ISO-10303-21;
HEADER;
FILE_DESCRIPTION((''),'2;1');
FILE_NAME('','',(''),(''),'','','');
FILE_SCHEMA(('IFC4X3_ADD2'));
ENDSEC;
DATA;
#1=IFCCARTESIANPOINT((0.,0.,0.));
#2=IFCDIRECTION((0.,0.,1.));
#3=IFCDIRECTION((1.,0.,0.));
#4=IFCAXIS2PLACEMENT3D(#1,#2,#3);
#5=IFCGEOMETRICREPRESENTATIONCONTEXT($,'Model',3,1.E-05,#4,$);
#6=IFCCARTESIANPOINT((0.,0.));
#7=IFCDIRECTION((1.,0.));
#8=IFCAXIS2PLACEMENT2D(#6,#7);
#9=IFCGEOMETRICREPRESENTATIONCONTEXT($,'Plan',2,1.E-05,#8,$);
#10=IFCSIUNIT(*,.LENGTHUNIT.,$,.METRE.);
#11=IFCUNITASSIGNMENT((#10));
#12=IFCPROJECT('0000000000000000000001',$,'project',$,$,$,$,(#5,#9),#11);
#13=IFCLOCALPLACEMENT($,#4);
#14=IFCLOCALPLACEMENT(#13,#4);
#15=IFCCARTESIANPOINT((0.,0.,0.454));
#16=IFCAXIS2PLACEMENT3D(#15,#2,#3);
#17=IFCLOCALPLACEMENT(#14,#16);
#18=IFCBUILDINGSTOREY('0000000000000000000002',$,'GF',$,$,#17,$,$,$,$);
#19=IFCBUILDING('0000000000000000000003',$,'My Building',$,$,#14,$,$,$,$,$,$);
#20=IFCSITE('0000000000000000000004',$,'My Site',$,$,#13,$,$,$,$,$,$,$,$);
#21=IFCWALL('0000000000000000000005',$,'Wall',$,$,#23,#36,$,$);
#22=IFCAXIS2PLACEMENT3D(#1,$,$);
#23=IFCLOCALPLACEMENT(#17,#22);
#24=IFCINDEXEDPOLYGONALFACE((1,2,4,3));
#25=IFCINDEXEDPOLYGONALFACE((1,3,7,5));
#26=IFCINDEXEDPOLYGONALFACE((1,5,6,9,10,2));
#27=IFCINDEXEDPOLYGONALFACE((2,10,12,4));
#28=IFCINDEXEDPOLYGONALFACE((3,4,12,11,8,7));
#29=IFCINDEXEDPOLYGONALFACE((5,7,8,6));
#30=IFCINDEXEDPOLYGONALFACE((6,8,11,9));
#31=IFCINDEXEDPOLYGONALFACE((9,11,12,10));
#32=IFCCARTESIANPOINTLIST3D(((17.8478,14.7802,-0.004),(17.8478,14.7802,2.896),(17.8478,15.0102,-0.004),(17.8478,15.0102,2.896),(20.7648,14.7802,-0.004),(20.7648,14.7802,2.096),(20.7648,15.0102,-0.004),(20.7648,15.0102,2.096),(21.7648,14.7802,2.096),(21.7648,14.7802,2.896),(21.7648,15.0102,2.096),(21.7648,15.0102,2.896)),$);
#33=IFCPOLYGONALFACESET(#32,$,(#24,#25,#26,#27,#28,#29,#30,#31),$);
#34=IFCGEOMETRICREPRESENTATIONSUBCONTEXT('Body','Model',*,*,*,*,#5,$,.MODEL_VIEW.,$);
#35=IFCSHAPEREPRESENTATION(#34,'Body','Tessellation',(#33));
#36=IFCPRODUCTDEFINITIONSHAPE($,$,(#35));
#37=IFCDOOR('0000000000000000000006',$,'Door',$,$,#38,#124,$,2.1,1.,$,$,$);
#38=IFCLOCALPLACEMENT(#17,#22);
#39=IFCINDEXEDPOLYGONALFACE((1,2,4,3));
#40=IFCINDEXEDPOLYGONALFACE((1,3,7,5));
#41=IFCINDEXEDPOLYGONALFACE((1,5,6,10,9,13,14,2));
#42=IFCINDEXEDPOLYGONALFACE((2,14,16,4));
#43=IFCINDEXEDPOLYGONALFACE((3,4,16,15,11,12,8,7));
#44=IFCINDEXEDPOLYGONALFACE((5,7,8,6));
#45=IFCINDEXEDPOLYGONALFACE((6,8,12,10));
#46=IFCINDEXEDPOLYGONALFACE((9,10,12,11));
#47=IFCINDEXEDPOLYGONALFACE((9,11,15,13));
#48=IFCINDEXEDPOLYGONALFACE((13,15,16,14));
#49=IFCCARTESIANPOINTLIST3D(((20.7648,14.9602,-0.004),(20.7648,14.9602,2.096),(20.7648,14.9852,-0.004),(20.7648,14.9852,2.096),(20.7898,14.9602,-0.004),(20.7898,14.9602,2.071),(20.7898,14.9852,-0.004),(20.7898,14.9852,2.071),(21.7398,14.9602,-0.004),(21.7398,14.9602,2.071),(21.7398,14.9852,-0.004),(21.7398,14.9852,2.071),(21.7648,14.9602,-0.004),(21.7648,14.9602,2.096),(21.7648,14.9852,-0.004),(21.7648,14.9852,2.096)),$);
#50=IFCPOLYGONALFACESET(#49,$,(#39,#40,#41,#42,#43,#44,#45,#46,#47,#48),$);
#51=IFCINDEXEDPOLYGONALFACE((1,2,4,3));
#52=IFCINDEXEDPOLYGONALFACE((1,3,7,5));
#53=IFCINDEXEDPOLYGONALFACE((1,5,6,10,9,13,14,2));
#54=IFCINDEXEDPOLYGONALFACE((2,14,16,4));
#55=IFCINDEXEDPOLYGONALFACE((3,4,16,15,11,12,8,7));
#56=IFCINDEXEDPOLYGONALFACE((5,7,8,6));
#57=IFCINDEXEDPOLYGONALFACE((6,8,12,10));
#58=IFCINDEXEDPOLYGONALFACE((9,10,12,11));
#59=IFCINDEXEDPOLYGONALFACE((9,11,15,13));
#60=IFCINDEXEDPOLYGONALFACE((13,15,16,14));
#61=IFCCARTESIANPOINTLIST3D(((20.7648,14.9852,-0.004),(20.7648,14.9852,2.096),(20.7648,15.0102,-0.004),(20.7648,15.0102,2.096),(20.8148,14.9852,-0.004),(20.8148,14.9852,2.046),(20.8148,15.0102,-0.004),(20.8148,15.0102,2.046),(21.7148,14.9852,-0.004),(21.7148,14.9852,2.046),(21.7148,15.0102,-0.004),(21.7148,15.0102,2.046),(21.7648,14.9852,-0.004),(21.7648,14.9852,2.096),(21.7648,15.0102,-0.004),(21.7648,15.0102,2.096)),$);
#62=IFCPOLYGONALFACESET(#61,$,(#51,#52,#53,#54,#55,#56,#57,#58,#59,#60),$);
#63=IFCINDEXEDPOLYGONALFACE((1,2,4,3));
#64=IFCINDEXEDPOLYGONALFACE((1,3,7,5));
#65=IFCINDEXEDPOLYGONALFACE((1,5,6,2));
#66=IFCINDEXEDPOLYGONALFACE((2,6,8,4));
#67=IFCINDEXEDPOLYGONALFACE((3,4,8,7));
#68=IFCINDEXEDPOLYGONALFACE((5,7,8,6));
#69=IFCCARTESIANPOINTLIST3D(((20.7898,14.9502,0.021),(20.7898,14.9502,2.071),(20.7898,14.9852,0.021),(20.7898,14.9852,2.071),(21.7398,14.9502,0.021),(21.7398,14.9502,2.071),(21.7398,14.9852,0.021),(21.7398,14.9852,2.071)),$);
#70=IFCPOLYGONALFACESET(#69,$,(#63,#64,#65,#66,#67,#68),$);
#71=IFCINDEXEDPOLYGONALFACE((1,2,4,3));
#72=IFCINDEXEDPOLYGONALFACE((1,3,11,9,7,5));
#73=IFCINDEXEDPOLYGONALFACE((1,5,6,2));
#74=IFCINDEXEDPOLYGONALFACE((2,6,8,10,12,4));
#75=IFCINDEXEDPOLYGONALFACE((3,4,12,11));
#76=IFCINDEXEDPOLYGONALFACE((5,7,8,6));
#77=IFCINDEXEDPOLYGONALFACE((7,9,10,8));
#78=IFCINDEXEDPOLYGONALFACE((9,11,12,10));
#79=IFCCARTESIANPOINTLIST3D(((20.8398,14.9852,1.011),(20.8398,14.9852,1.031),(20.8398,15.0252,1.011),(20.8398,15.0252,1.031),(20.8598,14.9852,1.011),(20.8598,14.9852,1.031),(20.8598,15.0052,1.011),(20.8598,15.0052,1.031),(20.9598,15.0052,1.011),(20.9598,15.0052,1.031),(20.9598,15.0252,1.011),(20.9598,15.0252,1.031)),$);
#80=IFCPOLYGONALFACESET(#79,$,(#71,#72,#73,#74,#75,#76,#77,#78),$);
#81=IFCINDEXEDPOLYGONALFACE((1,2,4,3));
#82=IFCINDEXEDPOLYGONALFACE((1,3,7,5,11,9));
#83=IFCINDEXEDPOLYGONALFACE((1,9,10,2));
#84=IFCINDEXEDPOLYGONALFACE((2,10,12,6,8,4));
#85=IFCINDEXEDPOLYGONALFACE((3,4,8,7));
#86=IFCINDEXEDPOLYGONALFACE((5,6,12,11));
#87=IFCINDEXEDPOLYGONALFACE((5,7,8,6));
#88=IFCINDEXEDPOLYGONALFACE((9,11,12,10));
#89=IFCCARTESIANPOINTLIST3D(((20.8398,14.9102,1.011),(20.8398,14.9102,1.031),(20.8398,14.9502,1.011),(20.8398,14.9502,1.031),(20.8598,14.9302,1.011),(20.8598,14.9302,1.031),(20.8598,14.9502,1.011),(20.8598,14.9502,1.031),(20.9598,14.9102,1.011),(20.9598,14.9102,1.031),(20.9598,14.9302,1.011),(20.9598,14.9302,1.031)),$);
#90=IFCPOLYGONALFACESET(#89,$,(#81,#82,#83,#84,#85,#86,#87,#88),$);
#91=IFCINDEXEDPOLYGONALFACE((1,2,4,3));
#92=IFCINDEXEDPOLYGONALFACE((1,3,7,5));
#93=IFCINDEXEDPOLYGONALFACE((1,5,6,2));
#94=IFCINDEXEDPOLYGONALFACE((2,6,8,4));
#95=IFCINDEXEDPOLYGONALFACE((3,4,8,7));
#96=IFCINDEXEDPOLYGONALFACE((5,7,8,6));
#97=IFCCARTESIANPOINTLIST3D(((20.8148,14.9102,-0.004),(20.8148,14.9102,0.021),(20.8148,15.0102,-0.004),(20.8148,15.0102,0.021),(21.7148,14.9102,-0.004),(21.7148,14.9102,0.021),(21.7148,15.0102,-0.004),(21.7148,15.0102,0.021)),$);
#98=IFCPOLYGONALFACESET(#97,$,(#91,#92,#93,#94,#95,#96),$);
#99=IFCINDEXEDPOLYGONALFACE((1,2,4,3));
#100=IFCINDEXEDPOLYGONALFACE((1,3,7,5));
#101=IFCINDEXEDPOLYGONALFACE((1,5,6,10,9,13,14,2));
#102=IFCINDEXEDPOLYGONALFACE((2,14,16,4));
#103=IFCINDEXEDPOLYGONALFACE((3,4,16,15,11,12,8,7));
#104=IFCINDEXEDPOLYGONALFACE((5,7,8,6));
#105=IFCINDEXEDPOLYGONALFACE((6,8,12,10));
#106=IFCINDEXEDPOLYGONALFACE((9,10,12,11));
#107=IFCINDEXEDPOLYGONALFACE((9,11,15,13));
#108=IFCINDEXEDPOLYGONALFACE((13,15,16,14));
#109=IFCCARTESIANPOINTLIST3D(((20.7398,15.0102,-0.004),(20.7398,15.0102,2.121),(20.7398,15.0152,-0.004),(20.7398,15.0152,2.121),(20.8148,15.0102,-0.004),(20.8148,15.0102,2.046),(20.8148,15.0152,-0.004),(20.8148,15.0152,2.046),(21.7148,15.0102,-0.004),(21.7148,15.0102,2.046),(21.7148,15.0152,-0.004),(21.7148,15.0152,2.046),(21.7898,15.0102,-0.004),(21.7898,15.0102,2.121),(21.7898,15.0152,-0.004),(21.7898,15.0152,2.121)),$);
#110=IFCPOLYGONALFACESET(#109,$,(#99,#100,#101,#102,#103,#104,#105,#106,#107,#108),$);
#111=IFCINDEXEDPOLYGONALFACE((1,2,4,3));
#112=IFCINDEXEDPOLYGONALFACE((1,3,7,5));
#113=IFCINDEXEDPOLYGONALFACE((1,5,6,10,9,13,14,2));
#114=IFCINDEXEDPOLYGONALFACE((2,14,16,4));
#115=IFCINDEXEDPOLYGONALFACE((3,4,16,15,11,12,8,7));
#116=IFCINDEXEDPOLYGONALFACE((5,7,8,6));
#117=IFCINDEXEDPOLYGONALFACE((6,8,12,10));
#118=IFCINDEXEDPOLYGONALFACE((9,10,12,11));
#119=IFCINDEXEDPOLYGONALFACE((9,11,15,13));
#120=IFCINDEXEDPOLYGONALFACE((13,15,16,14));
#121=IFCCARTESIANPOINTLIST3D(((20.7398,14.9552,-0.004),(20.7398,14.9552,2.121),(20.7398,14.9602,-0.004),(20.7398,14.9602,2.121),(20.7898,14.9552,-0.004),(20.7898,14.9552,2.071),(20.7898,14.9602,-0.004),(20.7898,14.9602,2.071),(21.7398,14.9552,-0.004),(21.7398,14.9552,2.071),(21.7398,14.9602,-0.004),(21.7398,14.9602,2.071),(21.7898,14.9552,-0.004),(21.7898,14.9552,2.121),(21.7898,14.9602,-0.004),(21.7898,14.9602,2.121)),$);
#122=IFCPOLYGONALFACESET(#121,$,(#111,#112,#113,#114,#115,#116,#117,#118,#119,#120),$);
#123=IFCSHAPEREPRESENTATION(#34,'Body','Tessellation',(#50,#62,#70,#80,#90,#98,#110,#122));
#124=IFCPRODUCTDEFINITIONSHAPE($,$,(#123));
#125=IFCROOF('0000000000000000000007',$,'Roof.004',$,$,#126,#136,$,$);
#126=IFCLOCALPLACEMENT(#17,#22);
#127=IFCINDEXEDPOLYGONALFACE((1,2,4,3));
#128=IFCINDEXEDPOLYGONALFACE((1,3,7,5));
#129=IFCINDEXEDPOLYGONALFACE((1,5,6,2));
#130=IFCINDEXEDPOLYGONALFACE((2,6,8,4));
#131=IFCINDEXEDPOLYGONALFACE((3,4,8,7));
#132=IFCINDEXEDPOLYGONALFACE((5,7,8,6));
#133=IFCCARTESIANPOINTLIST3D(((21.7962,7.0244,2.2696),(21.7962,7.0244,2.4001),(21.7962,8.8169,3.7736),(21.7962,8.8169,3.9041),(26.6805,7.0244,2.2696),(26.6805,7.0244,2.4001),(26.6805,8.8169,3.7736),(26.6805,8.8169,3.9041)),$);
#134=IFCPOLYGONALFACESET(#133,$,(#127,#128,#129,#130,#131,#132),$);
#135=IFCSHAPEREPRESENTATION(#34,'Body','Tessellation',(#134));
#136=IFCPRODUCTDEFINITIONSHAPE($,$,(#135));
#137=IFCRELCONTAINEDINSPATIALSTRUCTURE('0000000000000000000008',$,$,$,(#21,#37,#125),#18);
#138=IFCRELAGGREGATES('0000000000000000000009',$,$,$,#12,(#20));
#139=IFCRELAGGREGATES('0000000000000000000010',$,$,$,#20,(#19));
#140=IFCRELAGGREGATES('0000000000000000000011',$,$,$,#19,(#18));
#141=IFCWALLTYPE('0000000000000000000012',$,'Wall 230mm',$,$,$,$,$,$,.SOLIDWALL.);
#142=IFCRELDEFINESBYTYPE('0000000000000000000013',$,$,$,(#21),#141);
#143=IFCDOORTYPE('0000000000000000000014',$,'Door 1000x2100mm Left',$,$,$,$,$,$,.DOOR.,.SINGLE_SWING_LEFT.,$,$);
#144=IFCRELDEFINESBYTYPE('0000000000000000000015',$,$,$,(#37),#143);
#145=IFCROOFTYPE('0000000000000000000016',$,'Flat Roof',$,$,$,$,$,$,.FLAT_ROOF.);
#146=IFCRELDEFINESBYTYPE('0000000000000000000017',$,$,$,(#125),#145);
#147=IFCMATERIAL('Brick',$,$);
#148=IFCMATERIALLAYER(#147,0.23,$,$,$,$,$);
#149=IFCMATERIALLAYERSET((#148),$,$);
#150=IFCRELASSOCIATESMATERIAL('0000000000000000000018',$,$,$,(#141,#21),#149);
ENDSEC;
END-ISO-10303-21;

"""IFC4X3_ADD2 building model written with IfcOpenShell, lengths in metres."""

from ifc_helpers import new_model, entity, si_unit, frame, origin_with_axes, origin_2d_with_axis, place, context, subcontext, project, spatial, polyline, line, indexed_curve, outline, extrude, shape, source, transform, mapped, material, layer, layer_set, layer_usage, type_object, type_shapes, element, fill, save


model = new_model("IFC4X3_ADD2")

# Units and contexts
model_context = context("Model", 3, precision=1e-05, world=origin_with_axes())
plan_context = context("Plan", 2, precision=1e-05, world=origin_2d_with_axis())
body_context_1 = subcontext(model_context, "Body", "Model", "MODEL_VIEW")
body_context_2 = subcontext(plan_context, "Body", "Plan", "PLAN_VIEW")
ifc_project = project(units=[si_unit("LENGTHUNIT", "METRE")], contexts=[model_context, plan_context])

# Site, building, storey
site_placement = place(None, origin_with_axes())
site = spatial("IfcSite", under=ifc_project, at=site_placement, Name="My Site")
building_placement = place(site_placement, origin_with_axes())
building = spatial("IfcBuilding", under=site, at=building_placement, Name="My Building")
storey_placement = place(building_placement, frame((0.0, 0.0, 0.454), z_axis=(0.0, 0.0, 1.0), x_axis=(1.0, 0.0, 0.0)))
storey = spatial("IfcBuildingStorey", under=building, at=storey_placement, Name="GF")

# Shared definitions
ifc_material_1 = material(Name="Brick")
ifc_layer_1 = layer(ifc_material_1, 0.23)
ifc_layer_set_1 = layer_set([ifc_layer_1])
wall_type = type_object("IfcWallType", Name="Wall 230mm", PredefinedType="SOLIDWALL", material=ifc_layer_set_1)

# Wall, opening, door
ifc_layer_usage_1 = layer_usage(ifc_layer_set_1, "AXIS2", "POSITIVE", 0.0)
wall_1_placement = place(storey_placement, frame((21.7648, 15.0102, -0.004), z_axis=(0.0, 0.0, 1.0), x_axis=(-1.0, 0.0, 0.0)))
wall_1 = element("IfcWall", 1, at=wall_1_placement, inside=storey, type_object=wall_type, material=ifc_layer_usage_1, Name="Wall", context=body_context_1, shape_type="SweptSolid", body=[
    extrude(outline(indexed_curve([(0.0, 0.0), (0.0, 0.23), (3.917, 0.23), (3.917, 0.0), (0.0, 0.0)], self_intersect=False)), origin_with_axes(), (0.0, 0.0, 1.0), 2.9),
])
shared_shape_1 = source(origin_with_axes(), body_context_1, "Body", "SweptSolid", [
    extrude(outline(indexed_curve([(0.0, 0.0), (1.0, 0.0), (1.0, 2.1), (0.0, 2.1)], segments=[line(1, 2, 3, 4, 1)])), frame((0.0, -0.6, 0.0), z_axis=(0.0, -1.0, 0.0), x_axis=(1.0, 0.0, 0.0)), (0.0, 0.0, -1.0), 1.2),
])
opening_1_placement = place(wall_1_placement, frame((0.0, 0.0, 0.0), z_axis=(0.0, 0.0, 1.0), x_axis=(1.0, 0.0, 0.0)))
opening_1 = element("IfcOpeningElement", 2, at=opening_1_placement, cuts=wall_1, PredefinedType="OPENING", context=body_context_1, shape_type="MappedRepresentation", body=[
    mapped(shared_shape_1, transform((0.0, 0.0, 0.0), x_axis=(1.0, 0.0, 0.0), y_axis=(0.0, 1.0, 0.0), z_axis=(0.0, 0.0, 1.0), scale=1.0)),
])
door_type = type_object("IfcDoorType", Name="Door 1000x2100mm Left", OperationType="SINGLE_SWING_LEFT", PredefinedType="DOOR")
shared_shape_2 = source(origin_with_axes(), body_context_1, "Body", "SweptSolid", [
    extrude(outline(indexed_curve([(0.0, 0.0), (0.0, 2.1), (1.0, 2.1), (1.0, 0.0), (0.975, 0.0), (0.975, 2.075), (0.025, 2.075), (0.025, 0.0)], segments=[line(1, 2, 3, 4, 5, 6, 7, 8, 1)])), frame((0.0, 0.025, 0.0), z_axis=(0.0, -1.0, 0.0), x_axis=(1.0, 0.0, 0.0)), (0.0, 0.0, -1.0), 0.025),
    extrude(outline(indexed_curve([(0.0, 0.0), (0.0, 2.1), (1.0, 2.1), (1.0, 0.0), (0.95, 0.0), (0.95, 2.05), (0.05, 2.05), (0.05, 0.0)], segments=[line(1, 2, 3, 4, 5, 6, 7, 8, 1)])), frame((0.0, 0.0, 0.0), z_axis=(0.0, -1.0, 0.0), x_axis=(1.0, 0.0, 0.0)), (0.0, 0.0, -1.0), 0.025),
    extrude(outline(indexed_curve([(0.0, 0.0), (0.95, 0.0), (0.95, 0.035), (0.0, 0.035)], segments=[line(1, 2, 3, 4, 1)])), frame((0.025, 0.025, 0.025), z_axis=(0.0, 0.0, 1.0), x_axis=(1.0, 0.0, 0.0)), (0.0, 0.0, 1.0), 2.05),
    extrude(outline(indexed_curve([(0.0, 0.0), (0.0, -0.04), (-0.12, -0.04), (-0.12, -0.02), (-0.02, -0.02), (-0.02, 0.0)], segments=[line(1, 2, 3, 4, 5, 6, 1)])), frame((0.925, 0.025, 1.015), z_axis=(0.0, 0.0, 1.0), x_axis=(1.0, 0.0, 0.0)), (0.0, 0.0, 1.0), 0.02),
    extrude(outline(indexed_curve([(0.0, 0.0), (0.0, 0.04), (-0.12, 0.04), (-0.12, 0.02), (-0.02, 0.02), (-0.02, 0.0)], segments=[line(1, 2, 3, 4, 5, 6, 1)])), frame((0.925, 0.06, 1.015), z_axis=(0.0, 0.0, 1.0), x_axis=(1.0, 0.0, 0.0)), (0.0, 0.0, 1.0), 0.02),
    extrude(outline(indexed_curve([(0.0, 0.0), (0.9, 0.0), (0.9, 0.1), (0.0, 0.1)], segments=[line(1, 2, 3, 4, 1)])), frame((0.05, 0.0, 0.0), z_axis=(0.0, 0.0, 1.0), x_axis=(1.0, 0.0, 0.0)), (0.0, 0.0, 1.0), 0.025),
    extrude(outline(indexed_curve([(0.0, 0.0), (0.0, 2.125), (1.05, 2.125), (1.05, 0.0), (0.975, 0.0), (0.975, 2.05), (0.075, 2.05), (0.075, 0.0)], segments=[line(1, 2, 3, 4, 5, 6, 7, 8, 1)])), frame((-0.025, -0.005, 0.0), z_axis=(0.0, -1.0, 0.0), x_axis=(1.0, 0.0, 0.0)), (0.0, 0.0, -1.0), 0.005),
    extrude(outline(indexed_curve([(0.0, 0.0), (0.0, 2.125), (1.05, 2.125), (1.05, 0.0), (1.0, 0.0), (1.0, 2.075), (0.05, 2.075), (0.05, 0.0)], segments=[line(1, 2, 3, 4, 5, 6, 7, 8, 1)])), frame((-0.025, 0.05, 0.0), z_axis=(0.0, -1.0, 0.0), x_axis=(1.0, 0.0, 0.0)), (0.0, 0.0, -1.0), 0.005),
])
shared_shape_3 = source(origin_with_axes(), body_context_2, "Body", "Curve2D", [
    entity("IfcIndexedPolyCurve", entity("IfcCartesianPointList2D", [[0.0, 0.0], [0.0, 0.05], [0.025, 0.05], [0.025, 0.025], [0.05, 0.025], [0.05, 0.0]]), [entity("IfcLineIndex", [1, 2, 3, 4, 5, 6, 1])]),
    entity("IfcIndexedPolyCurve", entity("IfcCartesianPointList2D", [[1.0, 0.0], [1.0, 0.05], [0.975, 0.05], [0.975, 0.025], [0.95, 0.025], [0.95, 0.0]]), [entity("IfcLineIndex", [1, 2, 3, 4, 5, 6, 1])]),
    entity("IfcTrimmedCurve", entity("IfcEllipse", entity("IfcAxis2Placement2D", entity("IfcCartesianPoint", [0.06, 0.05]), entity("IfcDirection", [1.0, 0.0])), 0.915, 0.95), [entity("IfcCartesianPoint", [0.975, 0.05])], [entity("IfcCartesianPoint", [0.06, 1.0])], True, "CARTESIAN"),
    entity("IfcIndexedPolyCurve", entity("IfcCartesianPointList2D", [[0.025, 0.05], [0.06, 0.05], [0.06, 1.0], [0.025, 1.0]]), [entity("IfcLineIndex", [1, 2, 3, 4, 1])]),
])
type_shapes(door_type, [shared_shape_2, shared_shape_3])
door_placement = place(opening_1_placement, frame((0.0, 0.0, 0.0), z_axis=(0.0, 0.0, 1.0), x_axis=(1.0, 0.0, 0.0)))
door = element("IfcDoor", 3, at=door_placement, inside=storey, type_object=door_type, Name="Door", OverallHeight=2.1, OverallWidth=1.0, shapes=[
    shape(body_context_1, "Body", "MappedRepresentation", [mapped(shared_shape_2, transform((0.0, 0.0, 0.0), x_axis=(1.0, 0.0, 0.0), y_axis=(0.0, 1.0, 0.0), z_axis=(0.0, 0.0, 1.0), scale=1.0))]),
    shape(body_context_2, "Body", "MappedRepresentation", [mapped(shared_shape_3, transform((0.0, 0.0, 0.0), x_axis=(1.0, 0.0, 0.0), y_axis=(0.0, 1.0, 0.0), z_axis=(0.0, 0.0, 1.0), scale=1.0))]),
])
fill(opening_1, door)

# Roof
roof_type = type_object("IfcRoofType", Name="Flat Roof", PredefinedType="FLAT_ROOF")
roof_placement = place(storey_placement, frame((21.7962, 8.0241, 3.1084), z_axis=(0.0, -0.642788, 0.766044), x_axis=(1.0, 0.0, 0.0)))
element("IfcRoof", 4, at=roof_placement, inside=storey, type_object=roof_type, Name="Roof.004", context=body_context_1, shape_type="SweptSolid", body=[
    extrude(outline(polyline([(-2.4421, -0.0653), (2.4421, -0.0653), (2.4421, 0.0653), (-2.4421, 0.0653), (-2.4421, -0.0653)])), frame((2.4421, 1.0768, 0.05), z_axis=(0.0, 0.766044, -0.642788), x_axis=(1.0, 0.0, 0.0)), (0.0, 0.642788, -0.766044), 2.3398),
])

save(model, "model.ifc")
